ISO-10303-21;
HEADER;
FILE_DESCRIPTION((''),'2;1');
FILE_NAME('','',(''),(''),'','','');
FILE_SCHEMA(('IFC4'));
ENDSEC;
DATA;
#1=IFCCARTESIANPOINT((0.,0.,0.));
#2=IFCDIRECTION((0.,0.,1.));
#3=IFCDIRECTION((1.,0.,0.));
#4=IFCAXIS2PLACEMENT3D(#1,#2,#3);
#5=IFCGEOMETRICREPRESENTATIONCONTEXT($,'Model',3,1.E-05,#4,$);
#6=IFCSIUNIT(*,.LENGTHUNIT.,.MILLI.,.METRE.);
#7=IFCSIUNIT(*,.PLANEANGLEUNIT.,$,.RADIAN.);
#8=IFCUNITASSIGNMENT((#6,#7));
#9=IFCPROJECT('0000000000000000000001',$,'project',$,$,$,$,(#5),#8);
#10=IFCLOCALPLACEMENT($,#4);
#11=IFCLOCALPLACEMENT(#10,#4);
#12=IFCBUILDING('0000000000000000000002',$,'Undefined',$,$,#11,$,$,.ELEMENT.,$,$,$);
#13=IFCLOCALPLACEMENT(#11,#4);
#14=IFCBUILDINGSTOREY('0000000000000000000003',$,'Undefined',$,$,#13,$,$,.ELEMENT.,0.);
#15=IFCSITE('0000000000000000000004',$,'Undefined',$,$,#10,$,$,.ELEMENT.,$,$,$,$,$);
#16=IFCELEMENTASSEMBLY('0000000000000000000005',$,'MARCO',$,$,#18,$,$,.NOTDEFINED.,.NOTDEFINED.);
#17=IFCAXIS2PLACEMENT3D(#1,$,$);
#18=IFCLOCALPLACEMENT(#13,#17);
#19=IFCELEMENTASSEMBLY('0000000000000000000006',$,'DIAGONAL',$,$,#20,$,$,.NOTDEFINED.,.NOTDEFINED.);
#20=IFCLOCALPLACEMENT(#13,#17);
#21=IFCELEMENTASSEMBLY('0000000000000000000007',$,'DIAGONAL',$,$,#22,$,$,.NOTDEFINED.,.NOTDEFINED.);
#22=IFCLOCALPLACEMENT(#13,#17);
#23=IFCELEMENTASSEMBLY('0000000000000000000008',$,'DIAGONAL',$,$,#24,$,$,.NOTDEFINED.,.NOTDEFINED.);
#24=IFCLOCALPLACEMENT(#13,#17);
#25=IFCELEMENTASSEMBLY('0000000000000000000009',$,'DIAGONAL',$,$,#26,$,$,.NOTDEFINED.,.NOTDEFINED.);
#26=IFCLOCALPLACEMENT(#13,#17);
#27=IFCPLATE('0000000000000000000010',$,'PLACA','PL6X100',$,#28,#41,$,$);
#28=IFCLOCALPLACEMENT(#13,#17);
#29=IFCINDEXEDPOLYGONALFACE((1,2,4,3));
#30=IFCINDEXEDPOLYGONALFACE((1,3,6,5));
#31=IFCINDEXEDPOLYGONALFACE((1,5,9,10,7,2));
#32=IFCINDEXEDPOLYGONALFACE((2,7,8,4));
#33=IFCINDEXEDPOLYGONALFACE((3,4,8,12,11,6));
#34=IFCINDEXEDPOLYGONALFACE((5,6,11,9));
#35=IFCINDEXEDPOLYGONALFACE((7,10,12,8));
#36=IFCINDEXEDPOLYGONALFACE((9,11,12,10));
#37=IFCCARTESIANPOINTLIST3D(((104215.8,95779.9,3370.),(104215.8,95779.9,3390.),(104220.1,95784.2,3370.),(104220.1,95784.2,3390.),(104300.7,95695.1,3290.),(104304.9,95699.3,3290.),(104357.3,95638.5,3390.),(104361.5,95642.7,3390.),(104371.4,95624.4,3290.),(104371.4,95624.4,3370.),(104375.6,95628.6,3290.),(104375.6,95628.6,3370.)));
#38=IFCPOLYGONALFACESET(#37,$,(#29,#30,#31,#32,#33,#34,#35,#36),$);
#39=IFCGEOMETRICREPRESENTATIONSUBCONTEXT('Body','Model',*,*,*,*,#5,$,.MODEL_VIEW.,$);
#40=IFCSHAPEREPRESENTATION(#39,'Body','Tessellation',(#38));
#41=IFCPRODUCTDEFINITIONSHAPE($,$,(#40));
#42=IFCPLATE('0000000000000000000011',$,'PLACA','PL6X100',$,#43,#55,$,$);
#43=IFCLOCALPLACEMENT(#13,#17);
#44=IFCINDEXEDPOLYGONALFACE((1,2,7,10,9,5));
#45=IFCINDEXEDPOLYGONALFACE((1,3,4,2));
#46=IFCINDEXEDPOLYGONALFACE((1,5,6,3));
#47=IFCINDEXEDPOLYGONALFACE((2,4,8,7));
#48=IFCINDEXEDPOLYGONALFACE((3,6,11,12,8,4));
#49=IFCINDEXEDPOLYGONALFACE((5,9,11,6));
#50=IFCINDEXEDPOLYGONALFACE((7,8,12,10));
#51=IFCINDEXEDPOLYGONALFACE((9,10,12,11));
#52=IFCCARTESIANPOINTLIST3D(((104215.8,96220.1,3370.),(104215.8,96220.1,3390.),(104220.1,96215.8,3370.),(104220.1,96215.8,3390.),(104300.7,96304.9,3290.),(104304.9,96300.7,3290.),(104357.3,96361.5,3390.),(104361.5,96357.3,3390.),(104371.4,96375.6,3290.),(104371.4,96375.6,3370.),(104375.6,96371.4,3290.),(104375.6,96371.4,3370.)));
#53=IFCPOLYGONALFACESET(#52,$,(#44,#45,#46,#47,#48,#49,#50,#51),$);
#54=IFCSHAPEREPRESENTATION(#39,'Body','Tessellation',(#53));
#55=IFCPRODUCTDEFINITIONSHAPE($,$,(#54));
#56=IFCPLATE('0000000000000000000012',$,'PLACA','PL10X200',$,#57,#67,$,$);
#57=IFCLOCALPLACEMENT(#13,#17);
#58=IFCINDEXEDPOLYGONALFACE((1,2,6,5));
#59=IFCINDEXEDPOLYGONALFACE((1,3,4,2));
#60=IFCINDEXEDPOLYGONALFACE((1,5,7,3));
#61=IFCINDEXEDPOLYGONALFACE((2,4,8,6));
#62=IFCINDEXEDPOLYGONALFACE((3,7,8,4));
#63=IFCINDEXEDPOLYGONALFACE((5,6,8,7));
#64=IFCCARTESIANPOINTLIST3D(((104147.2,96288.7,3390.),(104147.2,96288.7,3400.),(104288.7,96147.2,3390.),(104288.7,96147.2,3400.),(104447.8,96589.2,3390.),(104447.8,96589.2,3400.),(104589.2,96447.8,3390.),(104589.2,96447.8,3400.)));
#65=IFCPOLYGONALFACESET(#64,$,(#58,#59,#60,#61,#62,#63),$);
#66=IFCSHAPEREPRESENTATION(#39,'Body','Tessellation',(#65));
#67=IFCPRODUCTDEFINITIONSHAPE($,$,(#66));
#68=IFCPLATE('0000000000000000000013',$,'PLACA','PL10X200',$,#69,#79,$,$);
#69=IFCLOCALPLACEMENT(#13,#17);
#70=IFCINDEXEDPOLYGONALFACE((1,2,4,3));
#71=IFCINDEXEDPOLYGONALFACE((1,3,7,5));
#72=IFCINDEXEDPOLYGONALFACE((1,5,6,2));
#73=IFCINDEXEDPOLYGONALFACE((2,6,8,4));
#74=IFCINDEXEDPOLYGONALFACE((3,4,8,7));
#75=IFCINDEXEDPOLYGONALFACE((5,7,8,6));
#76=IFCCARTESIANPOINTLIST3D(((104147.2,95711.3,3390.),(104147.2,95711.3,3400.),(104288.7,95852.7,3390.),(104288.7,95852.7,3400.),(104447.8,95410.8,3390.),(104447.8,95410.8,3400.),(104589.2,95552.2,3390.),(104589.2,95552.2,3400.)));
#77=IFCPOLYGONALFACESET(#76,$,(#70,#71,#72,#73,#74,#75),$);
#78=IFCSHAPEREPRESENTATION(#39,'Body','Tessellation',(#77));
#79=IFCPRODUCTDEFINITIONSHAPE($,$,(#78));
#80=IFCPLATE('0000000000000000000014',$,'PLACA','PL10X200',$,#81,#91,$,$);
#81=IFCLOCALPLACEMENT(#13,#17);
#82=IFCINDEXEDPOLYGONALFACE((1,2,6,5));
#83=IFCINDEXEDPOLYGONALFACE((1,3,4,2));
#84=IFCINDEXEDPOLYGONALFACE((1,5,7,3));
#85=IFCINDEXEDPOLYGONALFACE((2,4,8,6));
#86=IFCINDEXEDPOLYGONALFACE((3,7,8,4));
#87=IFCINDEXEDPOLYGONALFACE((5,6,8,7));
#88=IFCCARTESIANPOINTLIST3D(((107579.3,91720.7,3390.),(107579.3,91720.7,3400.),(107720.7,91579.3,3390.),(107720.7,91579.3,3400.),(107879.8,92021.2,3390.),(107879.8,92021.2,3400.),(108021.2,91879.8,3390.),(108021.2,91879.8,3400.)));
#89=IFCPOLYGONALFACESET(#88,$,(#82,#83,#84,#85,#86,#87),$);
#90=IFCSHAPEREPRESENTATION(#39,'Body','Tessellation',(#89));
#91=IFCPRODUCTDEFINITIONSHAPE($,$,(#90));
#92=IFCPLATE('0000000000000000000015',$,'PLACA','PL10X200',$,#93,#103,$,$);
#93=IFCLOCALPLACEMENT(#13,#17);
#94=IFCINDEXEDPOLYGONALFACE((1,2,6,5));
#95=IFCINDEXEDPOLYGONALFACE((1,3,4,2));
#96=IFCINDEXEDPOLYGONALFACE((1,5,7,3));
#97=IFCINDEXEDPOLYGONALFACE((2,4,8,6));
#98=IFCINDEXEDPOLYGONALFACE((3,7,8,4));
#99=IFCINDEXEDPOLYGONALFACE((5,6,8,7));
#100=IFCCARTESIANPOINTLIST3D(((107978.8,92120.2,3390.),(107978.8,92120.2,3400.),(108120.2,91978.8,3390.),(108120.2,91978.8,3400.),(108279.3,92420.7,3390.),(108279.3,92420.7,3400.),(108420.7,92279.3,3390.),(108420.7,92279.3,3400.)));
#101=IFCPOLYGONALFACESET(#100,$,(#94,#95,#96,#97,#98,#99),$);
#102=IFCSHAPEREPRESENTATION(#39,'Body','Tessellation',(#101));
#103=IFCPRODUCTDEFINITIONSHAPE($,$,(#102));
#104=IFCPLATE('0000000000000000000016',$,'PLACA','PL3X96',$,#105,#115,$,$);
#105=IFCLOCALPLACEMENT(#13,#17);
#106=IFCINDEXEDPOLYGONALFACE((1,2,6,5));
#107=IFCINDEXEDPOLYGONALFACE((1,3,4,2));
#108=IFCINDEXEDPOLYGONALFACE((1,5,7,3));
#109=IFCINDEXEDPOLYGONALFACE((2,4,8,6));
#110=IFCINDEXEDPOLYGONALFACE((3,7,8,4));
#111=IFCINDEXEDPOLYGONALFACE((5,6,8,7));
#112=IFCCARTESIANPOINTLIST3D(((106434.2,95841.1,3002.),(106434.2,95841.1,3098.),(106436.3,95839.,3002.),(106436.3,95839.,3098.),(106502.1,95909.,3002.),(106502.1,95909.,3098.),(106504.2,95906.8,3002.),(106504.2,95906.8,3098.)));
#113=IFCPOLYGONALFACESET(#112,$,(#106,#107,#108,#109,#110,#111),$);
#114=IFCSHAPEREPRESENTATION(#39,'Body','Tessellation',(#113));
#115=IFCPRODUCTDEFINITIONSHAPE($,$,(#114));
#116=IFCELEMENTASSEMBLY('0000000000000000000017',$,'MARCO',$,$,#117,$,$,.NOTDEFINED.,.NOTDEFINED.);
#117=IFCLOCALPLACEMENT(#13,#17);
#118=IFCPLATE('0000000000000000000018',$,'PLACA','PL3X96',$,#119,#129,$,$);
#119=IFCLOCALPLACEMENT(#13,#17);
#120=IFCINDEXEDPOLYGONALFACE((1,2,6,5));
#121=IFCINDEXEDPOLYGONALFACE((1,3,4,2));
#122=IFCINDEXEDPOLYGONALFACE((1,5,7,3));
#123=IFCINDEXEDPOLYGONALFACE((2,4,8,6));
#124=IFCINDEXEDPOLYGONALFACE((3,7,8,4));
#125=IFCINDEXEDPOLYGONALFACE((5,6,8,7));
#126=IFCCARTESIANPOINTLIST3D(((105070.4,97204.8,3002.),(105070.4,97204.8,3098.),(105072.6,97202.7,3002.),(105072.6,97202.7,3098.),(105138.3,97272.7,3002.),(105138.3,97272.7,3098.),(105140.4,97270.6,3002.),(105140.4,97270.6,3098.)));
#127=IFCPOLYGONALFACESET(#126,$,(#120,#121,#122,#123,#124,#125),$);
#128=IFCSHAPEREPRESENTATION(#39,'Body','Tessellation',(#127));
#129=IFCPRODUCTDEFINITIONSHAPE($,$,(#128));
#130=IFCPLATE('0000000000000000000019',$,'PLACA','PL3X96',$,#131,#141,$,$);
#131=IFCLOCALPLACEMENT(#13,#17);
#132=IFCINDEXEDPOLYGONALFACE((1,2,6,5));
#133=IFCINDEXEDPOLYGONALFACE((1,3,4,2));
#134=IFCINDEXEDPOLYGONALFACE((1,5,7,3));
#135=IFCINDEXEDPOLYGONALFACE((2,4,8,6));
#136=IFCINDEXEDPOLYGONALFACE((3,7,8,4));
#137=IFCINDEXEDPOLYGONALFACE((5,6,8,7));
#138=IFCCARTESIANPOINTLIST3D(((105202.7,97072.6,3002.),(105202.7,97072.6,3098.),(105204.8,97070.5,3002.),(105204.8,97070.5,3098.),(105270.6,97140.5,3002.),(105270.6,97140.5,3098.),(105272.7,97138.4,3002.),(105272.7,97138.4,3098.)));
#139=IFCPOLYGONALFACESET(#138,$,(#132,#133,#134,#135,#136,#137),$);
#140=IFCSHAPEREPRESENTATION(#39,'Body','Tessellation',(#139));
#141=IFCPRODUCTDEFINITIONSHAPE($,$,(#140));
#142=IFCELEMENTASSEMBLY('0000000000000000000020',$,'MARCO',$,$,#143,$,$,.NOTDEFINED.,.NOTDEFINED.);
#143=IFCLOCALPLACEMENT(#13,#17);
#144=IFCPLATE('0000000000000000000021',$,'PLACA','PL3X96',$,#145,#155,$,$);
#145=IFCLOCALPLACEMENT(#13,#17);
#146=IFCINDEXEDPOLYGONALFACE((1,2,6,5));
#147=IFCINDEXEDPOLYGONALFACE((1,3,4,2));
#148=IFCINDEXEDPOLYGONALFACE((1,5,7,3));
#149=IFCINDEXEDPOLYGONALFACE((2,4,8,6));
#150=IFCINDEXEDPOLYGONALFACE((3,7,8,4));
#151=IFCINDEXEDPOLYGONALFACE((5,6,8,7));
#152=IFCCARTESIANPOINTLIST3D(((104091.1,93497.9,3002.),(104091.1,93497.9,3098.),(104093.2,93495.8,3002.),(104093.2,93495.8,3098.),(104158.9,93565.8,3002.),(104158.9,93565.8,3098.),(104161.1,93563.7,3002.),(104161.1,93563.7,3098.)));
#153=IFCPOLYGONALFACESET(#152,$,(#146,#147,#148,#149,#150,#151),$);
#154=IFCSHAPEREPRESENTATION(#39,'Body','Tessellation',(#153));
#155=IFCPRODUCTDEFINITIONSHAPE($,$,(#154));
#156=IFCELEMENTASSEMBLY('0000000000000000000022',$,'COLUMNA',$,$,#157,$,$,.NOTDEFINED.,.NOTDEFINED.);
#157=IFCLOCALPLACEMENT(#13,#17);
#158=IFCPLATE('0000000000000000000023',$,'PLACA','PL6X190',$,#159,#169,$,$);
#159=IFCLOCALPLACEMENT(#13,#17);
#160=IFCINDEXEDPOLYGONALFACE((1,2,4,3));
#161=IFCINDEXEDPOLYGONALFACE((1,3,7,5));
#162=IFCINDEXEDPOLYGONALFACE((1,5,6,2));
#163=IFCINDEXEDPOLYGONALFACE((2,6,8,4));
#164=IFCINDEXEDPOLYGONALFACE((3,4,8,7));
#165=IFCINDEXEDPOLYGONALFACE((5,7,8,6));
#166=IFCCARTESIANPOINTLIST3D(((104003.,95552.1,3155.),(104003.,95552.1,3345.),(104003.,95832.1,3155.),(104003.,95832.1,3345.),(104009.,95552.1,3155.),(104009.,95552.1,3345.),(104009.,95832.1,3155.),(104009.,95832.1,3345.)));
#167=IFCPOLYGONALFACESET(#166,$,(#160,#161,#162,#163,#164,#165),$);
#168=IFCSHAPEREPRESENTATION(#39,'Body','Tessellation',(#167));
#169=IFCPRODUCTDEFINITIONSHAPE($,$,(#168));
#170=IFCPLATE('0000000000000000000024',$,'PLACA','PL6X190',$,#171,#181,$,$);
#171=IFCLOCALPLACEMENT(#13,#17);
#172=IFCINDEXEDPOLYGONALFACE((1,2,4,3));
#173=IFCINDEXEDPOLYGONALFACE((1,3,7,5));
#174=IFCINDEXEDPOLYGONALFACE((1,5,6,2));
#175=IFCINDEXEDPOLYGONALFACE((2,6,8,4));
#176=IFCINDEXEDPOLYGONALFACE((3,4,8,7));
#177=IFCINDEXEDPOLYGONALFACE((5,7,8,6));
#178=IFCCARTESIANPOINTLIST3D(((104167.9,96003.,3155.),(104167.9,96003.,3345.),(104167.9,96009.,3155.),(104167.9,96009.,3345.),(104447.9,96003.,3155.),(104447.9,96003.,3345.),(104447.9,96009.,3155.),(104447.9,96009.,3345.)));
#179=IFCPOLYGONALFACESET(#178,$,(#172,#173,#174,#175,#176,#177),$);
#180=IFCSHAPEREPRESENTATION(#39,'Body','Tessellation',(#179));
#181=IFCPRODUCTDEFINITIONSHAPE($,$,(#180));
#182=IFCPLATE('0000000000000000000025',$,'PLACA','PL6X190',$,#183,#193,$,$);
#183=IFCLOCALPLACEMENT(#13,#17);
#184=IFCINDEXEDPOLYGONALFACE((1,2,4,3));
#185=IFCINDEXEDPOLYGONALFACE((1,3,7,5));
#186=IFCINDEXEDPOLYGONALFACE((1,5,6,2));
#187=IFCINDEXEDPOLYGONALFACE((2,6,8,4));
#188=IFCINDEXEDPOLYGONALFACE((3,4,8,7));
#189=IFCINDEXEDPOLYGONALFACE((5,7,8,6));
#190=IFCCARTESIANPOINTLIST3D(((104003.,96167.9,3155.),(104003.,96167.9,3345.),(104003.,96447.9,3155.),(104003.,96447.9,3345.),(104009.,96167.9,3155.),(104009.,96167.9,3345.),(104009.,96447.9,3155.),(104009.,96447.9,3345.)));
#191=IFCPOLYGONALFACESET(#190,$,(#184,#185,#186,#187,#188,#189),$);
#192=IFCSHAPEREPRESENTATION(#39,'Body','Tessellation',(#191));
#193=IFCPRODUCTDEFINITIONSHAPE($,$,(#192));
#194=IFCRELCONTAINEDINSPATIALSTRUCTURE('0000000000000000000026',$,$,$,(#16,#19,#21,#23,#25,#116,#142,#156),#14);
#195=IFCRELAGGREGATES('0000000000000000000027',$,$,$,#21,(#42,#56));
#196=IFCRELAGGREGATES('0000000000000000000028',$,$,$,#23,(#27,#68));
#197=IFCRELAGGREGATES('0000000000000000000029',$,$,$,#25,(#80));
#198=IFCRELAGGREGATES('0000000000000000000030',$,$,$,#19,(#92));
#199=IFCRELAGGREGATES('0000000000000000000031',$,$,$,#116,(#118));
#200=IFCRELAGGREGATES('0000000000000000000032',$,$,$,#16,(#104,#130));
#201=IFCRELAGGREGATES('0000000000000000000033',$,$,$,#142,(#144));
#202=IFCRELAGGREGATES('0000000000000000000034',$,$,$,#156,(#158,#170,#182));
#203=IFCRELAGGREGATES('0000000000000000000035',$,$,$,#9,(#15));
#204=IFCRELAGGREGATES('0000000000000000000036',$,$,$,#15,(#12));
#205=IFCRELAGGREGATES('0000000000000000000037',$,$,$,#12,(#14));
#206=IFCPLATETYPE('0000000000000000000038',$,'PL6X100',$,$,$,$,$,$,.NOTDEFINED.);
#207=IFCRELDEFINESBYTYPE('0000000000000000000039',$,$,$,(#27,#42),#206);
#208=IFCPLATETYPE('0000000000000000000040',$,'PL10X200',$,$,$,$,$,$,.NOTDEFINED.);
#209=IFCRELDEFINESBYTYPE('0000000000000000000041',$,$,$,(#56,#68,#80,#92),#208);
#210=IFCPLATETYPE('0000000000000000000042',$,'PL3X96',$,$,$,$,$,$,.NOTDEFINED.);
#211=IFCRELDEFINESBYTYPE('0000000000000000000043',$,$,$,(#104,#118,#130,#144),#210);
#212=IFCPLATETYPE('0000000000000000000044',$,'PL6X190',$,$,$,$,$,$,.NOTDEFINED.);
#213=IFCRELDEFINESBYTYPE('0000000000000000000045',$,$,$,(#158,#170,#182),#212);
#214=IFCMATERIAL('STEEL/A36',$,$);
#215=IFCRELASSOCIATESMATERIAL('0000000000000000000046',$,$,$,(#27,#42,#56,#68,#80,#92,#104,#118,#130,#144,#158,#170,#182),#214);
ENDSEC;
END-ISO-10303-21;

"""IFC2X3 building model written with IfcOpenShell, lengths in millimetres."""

from ifc_helpers import new_model, si_unit, frame, origin_with_axes, place, context, subcontext, project, spatial, polyline, outline, extrude, material, type_object, element, aggregate, save


model = new_model("IFC2X3")

# Units and contexts
model_context = context("Model", 3, precision=1e-05, world=origin_with_axes())
body_context = subcontext(model_context, "Body", "Model", "MODEL_VIEW")
ifc_project = project(units=[si_unit("LENGTHUNIT", "METRE", prefix="MILLI"), si_unit("PLANEANGLEUNIT", "RADIAN")], contexts=[model_context])

# Site, building, storey
site_placement = place(None, origin_with_axes())
site = spatial("IfcSite", under=ifc_project, at=site_placement, Name="Undefined", CompositionType="ELEMENT")
building_placement = place(site_placement, origin_with_axes())
building = spatial("IfcBuilding", under=site, at=building_placement, Name="Undefined", CompositionType="ELEMENT")
storey_placement = place(building_placement, origin_with_axes())
storey = spatial("IfcBuildingStorey", under=building, at=storey_placement, Name="Undefined", CompositionType="ELEMENT", Elevation=0.0)

# Shared definitions
ifc_material_1 = material(Name="STEEL/A36")

# Element assemblies
assembly_1_placement = place(storey_placement, origin_with_axes())
assembly_1 = element("IfcElementAssembly", 1, at=assembly_1_placement, inside=storey, Name="MARCO", AssemblyPlace="NOTDEFINED", PredefinedType="NOTDEFINED")
assembly_2_placement = place(storey_placement, origin_with_axes())
assembly_2 = element("IfcElementAssembly", 2, at=assembly_2_placement, inside=storey, Name="DIAGONAL", AssemblyPlace="NOTDEFINED", PredefinedType="NOTDEFINED")

# Element assemblies
assembly_3_placement = place(storey_placement, origin_with_axes())
assembly_3 = element("IfcElementAssembly", 3, at=assembly_3_placement, inside=storey, Name="DIAGONAL", AssemblyPlace="NOTDEFINED", PredefinedType="NOTDEFINED")
assembly_4_placement = place(storey_placement, origin_with_axes())
assembly_4 = element("IfcElementAssembly", 4, at=assembly_4_placement, inside=storey, Name="DIAGONAL", AssemblyPlace="NOTDEFINED", PredefinedType="NOTDEFINED")
assembly_5_placement = place(storey_placement, origin_with_axes())
assembly_5 = element("IfcElementAssembly", 5, at=assembly_5_placement, inside=storey, Name="DIAGONAL", AssemblyPlace="NOTDEFINED", PredefinedType="NOTDEFINED")

# Plates
plate_type_1 = type_object("IfcPlateType", Name="PL6X100", PredefinedType="NOTDEFINED")
plate_1_placement = place(assembly_4_placement, frame((104218.0, 95782.0, 3290.0), z_axis=(-0.707107, -0.707107, 0.0), x_axis=(0.707107, -0.707107, 0.0)))
plate_1 = element("IfcPlate", 6, at=plate_1_placement, type_object=plate_type_1, material=ifc_material_1, Name="PLACA", Description="PL6X100", context=body_context, shape_type="SweptSolid", body=[
    extrude(outline(polyline([(0.0, 80.0), (120.0, 0.0), (220.0, 0.0), (220.0, 80.0), (200.0, 100.0), (0.0, 100.0), (0.0, 80.0)])), frame((0.0, 0.0, -3.0), z_axis=(0.0, 0.0, 1.0), x_axis=(1.0, 0.0, 0.0)), (0.0, 0.0, 1.0), 6.0),
])
plate_2_placement = place(assembly_3_placement, frame((104218.0, 96218.0, 3290.0), z_axis=(0.707107, -0.707107, 0.0), x_axis=(0.707107, 0.707107, 0.0)))
plate_2 = element("IfcPlate", 7, at=plate_2_placement, type_object=plate_type_1, material=ifc_material_1, Name="PLACA", Description="PL6X100", context=body_context, shape_type="SweptSolid", body=[
    extrude(outline(polyline([(0.0, 80.0), (120.0, 0.0), (220.0, 0.0), (220.0, 80.0), (200.0, 100.0), (0.0, 100.0), (0.0, 80.0)])), frame((0.0, 0.0, -3.0), z_axis=(0.0, 0.0, 1.0), x_axis=(1.0, 0.0, 0.0)), (0.0, 0.0, 1.0), 6.0),
])
plate_type_2 = type_object("IfcPlateType", Name="PL10X200", PredefinedType="NOTDEFINED")
plate_3_placement = place(assembly_3_placement, frame((104218.0, 96218.0, 3395.0), z_axis=(0.0, 0.0, -1.0), x_axis=(0.707107, 0.707107, 0.0)))
plate_3 = element("IfcPlate", 8, at=plate_3_placement, type_object=plate_type_2, material=ifc_material_1, Name="PLACA", Description="PL10X200", context=body_context, shape_type="SweptSolid", body=[
    extrude(outline(polyline([(0.0, -100.0), (0.0, 100.0), (425.0, 100.0), (425.0, -100.0), (0.0, -100.0)])), frame((0.0, 0.0, -5.0), z_axis=(0.0, 0.0, 1.0), x_axis=(1.0, 0.0, 0.0)), (0.0, 0.0, 1.0), 10.0),
])
aggregate(assembly_3, [plate_2, plate_3])
plate_4_placement = place(assembly_4_placement, frame((104218.0, 95782.0, 3395.0), z_axis=(0.0, 0.0, -1.0), x_axis=(0.707107, -0.707107, 0.0)))
plate_4 = element("IfcPlate", 9, at=plate_4_placement, type_object=plate_type_2, material=ifc_material_1, Name="PLACA", Description="PL10X200", context=body_context, shape_type="SweptSolid", body=[
    extrude(outline(polyline([(0.0, -100.0), (0.0, 100.0), (425.0, 100.0), (425.0, -100.0), (0.0, -100.0)])), frame((0.0, 0.0, -5.0), z_axis=(0.0, 0.0, 1.0), x_axis=(1.0, 0.0, 0.0)), (0.0, 0.0, 1.0), 10.0),
])
aggregate(assembly_4, [plate_1, plate_4])
plate_5_placement = place(assembly_5_placement, frame((107950.5, 91950.5, 3395.0), z_axis=(0.0, 0.0, 1.0), x_axis=(-0.707107, -0.707107, 0.0)))
plate_5 = element("IfcPlate", 10, at=plate_5_placement, type_object=plate_type_2, material=ifc_material_1, Name="PLACA", Description="PL10X200", context=body_context, shape_type="SweptSolid", body=[
    extrude(outline(polyline([(0.0, -100.0), (0.0, 100.0), (425.0, 100.0), (425.0, -100.0), (0.0, -100.0)])), frame((0.0, 0.0, -5.0), z_axis=(0.0, 0.0, 1.0), x_axis=(1.0, 0.0, 0.0)), (0.0, 0.0, 1.0), 10.0),
])
aggregate(assembly_5, [plate_5])
plate_6_placement = place(assembly_2_placement, frame((108049.5, 92049.5, 3395.0), z_axis=(0.0, 0.0, 1.0), x_axis=(0.707107, 0.707107, 0.0)))
plate_6 = element("IfcPlate", 11, at=plate_6_placement, type_object=plate_type_2, material=ifc_material_1, Name="PLACA", Description="PL10X200", context=body_context, shape_type="SweptSolid", body=[
    extrude(outline(polyline([(0.0, -100.0), (0.0, 100.0), (425.0, 100.0), (425.0, -100.0), (0.0, -100.0)])), frame((0.0, 0.0, -5.0), z_axis=(0.0, 0.0, 1.0), x_axis=(1.0, 0.0, 0.0)), (0.0, 0.0, 1.0), 10.0),
])
aggregate(assembly_2, [plate_6])
plate_type_3 = type_object("IfcPlateType", Name="PL3X96", PredefinedType="NOTDEFINED")
plate_7_placement = place(assembly_1_placement, frame((106435.3, 95840.0, 3098.0), z_axis=(-0.70712, 0.707094, 0.0), x_axis=(0.707094, 0.70712, 0.0)))
plate_7 = element("IfcPlate", 12, at=plate_7_placement, type_object=plate_type_3, material=ifc_material_1, Name="PLACA", Description="PL3X96", context=body_context, shape_type="SweptSolid", body=[
    extrude(outline(polyline([(0.0, 0.0), (96.0, 0.0), (96.0, 96.0), (0.0, 96.0), (0.0, 0.0)])), frame((0.0, 0.0, -1.5), z_axis=(0.0, 0.0, 1.0), x_axis=(1.0, 0.0, 0.0)), (0.0, 0.0, 1.0), 3.0),
])

# Element assembly, plate
assembly_6_placement = place(storey_placement, origin_with_axes())
assembly_6 = element("IfcElementAssembly", 13, at=assembly_6_placement, inside=storey, Name="MARCO", AssemblyPlace="NOTDEFINED", PredefinedType="NOTDEFINED")
plate_8_placement = place(assembly_6_placement, frame((105071.5, 97203.8, 3098.0), z_axis=(-0.70712, 0.707094, 0.0), x_axis=(0.707094, 0.70712, 0.0)))
plate_8 = element("IfcPlate", 14, at=plate_8_placement, type_object=plate_type_3, material=ifc_material_1, Name="PLACA", Description="PL3X96", context=body_context, shape_type="SweptSolid", body=[
    extrude(outline(polyline([(0.0, 0.0), (96.0, 0.0), (96.0, 96.0), (0.0, 96.0), (0.0, 0.0)])), frame((0.0, 0.0, -1.5), z_axis=(0.0, 0.0, 1.0), x_axis=(1.0, 0.0, 0.0)), (0.0, 0.0, 1.0), 3.0),
])
aggregate(assembly_6, [plate_8])

# Plate
plate_9_placement = place(assembly_1_placement, frame((105271.6, 97139.4, 3098.0), z_axis=(0.70712, -0.707094, 0.0), x_axis=(-0.707094, -0.70712, 0.0)))
plate_9 = element("IfcPlate", 15, at=plate_9_placement, type_object=plate_type_3, material=ifc_material_1, Name="PLACA", Description="PL3X96", context=body_context, shape_type="SweptSolid", body=[
    extrude(outline(polyline([(0.0, 0.0), (96.0, 0.0), (96.0, 96.0), (0.0, 96.0), (0.0, 0.0)])), frame((0.0, 0.0, -1.5), z_axis=(0.0, 0.0, 1.0), x_axis=(1.0, 0.0, 0.0)), (0.0, 0.0, 1.0), 3.0),
])
aggregate(assembly_1, [plate_7, plate_9])

# Element assembly, plate
assembly_7_placement = place(storey_placement, origin_with_axes())
assembly_7 = element("IfcElementAssembly", 16, at=assembly_7_placement, inside=storey, Name="MARCO", AssemblyPlace="NOTDEFINED", PredefinedType="NOTDEFINED")
plate_10_placement = place(assembly_7_placement, frame((104092.1, 93496.9, 3098.0), z_axis=(-0.707106, 0.707108, 0.0), x_axis=(0.707108, 0.707106, 0.0)))
plate_10 = element("IfcPlate", 17, at=plate_10_placement, type_object=plate_type_3, material=ifc_material_1, Name="PLACA", Description="PL3X96", context=body_context, shape_type="SweptSolid", body=[
    extrude(outline(polyline([(0.0, 0.0), (96.0, 0.0), (96.0, 96.0), (0.0, 96.0), (0.0, 0.0)])), frame((0.0, 0.0, -1.5), z_axis=(0.0, 0.0, 1.0), x_axis=(1.0, 0.0, 0.0)), (0.0, 0.0, 1.0), 3.0),
])
aggregate(assembly_7, [plate_10])

# Element assembly, plates
assembly_8_placement = place(storey_placement, origin_with_axes())
assembly_8 = element("IfcElementAssembly", 18, at=assembly_8_placement, inside=storey, Name="COLUMNA", AssemblyPlace="NOTDEFINED", PredefinedType="NOTDEFINED")
plate_type_4 = type_object("IfcPlateType", Name="PL6X190", PredefinedType="NOTDEFINED")
plate_11_placement = place(assembly_8_placement, frame((104006.0, 95552.1, 3250.0), z_axis=(1.0, 0.0, 0.0), x_axis=(0.0, 1.0, 0.0)))
plate_11 = element("IfcPlate", 19, at=plate_11_placement, type_object=plate_type_4, material=ifc_material_1, Name="PLACA", Description="PL6X190", context=body_context, shape_type="SweptSolid", body=[
    extrude(outline(polyline([(0.0, -95.0), (0.0, 95.0), (280.0, 95.0), (280.0, -95.0), (0.0, -95.0)])), frame((0.0, 0.0, -3.0), z_axis=(0.0, 0.0, 1.0), x_axis=(1.0, 0.0, 0.0)), (0.0, 0.0, 1.0), 6.0),
])
plate_12_placement = place(assembly_8_placement, frame((104447.9, 96006.0, 3250.0), z_axis=(0.0, 1.0, 0.0), x_axis=(-1.0, 0.0, 0.0)))
plate_12 = element("IfcPlate", 20, at=plate_12_placement, type_object=plate_type_4, material=ifc_material_1, Name="PLACA", Description="PL6X190", context=body_context, shape_type="SweptSolid", body=[
    extrude(outline(polyline([(0.0, -95.0), (0.0, 95.0), (280.0, 95.0), (280.0, -95.0), (0.0, -95.0)])), frame((0.0, 0.0, -3.0), z_axis=(0.0, 0.0, 1.0), x_axis=(1.0, 0.0, 0.0)), (0.0, 0.0, 1.0), 6.0),
])
plate_13_placement = place(assembly_8_placement, frame((104006.0, 96447.9, 3250.0), z_axis=(-1.0, 0.0, 0.0), x_axis=(0.0, -1.0, 0.0)))
plate_13 = element("IfcPlate", 21, at=plate_13_placement, type_object=plate_type_4, material=ifc_material_1, Name="PLACA", Description="PL6X190", context=body_context, shape_type="SweptSolid", body=[
    extrude(outline(polyline([(0.0, -95.0), (0.0, 95.0), (280.0, 95.0), (280.0, -95.0), (0.0, -95.0)])), frame((0.0, 0.0, -3.0), z_axis=(0.0, 0.0, 1.0), x_axis=(1.0, 0.0, 0.0)), (0.0, 0.0, 1.0), 6.0),
])

aggregate(assembly_8, [plate_11, plate_12, plate_13])

save(model, "model.ifc")
